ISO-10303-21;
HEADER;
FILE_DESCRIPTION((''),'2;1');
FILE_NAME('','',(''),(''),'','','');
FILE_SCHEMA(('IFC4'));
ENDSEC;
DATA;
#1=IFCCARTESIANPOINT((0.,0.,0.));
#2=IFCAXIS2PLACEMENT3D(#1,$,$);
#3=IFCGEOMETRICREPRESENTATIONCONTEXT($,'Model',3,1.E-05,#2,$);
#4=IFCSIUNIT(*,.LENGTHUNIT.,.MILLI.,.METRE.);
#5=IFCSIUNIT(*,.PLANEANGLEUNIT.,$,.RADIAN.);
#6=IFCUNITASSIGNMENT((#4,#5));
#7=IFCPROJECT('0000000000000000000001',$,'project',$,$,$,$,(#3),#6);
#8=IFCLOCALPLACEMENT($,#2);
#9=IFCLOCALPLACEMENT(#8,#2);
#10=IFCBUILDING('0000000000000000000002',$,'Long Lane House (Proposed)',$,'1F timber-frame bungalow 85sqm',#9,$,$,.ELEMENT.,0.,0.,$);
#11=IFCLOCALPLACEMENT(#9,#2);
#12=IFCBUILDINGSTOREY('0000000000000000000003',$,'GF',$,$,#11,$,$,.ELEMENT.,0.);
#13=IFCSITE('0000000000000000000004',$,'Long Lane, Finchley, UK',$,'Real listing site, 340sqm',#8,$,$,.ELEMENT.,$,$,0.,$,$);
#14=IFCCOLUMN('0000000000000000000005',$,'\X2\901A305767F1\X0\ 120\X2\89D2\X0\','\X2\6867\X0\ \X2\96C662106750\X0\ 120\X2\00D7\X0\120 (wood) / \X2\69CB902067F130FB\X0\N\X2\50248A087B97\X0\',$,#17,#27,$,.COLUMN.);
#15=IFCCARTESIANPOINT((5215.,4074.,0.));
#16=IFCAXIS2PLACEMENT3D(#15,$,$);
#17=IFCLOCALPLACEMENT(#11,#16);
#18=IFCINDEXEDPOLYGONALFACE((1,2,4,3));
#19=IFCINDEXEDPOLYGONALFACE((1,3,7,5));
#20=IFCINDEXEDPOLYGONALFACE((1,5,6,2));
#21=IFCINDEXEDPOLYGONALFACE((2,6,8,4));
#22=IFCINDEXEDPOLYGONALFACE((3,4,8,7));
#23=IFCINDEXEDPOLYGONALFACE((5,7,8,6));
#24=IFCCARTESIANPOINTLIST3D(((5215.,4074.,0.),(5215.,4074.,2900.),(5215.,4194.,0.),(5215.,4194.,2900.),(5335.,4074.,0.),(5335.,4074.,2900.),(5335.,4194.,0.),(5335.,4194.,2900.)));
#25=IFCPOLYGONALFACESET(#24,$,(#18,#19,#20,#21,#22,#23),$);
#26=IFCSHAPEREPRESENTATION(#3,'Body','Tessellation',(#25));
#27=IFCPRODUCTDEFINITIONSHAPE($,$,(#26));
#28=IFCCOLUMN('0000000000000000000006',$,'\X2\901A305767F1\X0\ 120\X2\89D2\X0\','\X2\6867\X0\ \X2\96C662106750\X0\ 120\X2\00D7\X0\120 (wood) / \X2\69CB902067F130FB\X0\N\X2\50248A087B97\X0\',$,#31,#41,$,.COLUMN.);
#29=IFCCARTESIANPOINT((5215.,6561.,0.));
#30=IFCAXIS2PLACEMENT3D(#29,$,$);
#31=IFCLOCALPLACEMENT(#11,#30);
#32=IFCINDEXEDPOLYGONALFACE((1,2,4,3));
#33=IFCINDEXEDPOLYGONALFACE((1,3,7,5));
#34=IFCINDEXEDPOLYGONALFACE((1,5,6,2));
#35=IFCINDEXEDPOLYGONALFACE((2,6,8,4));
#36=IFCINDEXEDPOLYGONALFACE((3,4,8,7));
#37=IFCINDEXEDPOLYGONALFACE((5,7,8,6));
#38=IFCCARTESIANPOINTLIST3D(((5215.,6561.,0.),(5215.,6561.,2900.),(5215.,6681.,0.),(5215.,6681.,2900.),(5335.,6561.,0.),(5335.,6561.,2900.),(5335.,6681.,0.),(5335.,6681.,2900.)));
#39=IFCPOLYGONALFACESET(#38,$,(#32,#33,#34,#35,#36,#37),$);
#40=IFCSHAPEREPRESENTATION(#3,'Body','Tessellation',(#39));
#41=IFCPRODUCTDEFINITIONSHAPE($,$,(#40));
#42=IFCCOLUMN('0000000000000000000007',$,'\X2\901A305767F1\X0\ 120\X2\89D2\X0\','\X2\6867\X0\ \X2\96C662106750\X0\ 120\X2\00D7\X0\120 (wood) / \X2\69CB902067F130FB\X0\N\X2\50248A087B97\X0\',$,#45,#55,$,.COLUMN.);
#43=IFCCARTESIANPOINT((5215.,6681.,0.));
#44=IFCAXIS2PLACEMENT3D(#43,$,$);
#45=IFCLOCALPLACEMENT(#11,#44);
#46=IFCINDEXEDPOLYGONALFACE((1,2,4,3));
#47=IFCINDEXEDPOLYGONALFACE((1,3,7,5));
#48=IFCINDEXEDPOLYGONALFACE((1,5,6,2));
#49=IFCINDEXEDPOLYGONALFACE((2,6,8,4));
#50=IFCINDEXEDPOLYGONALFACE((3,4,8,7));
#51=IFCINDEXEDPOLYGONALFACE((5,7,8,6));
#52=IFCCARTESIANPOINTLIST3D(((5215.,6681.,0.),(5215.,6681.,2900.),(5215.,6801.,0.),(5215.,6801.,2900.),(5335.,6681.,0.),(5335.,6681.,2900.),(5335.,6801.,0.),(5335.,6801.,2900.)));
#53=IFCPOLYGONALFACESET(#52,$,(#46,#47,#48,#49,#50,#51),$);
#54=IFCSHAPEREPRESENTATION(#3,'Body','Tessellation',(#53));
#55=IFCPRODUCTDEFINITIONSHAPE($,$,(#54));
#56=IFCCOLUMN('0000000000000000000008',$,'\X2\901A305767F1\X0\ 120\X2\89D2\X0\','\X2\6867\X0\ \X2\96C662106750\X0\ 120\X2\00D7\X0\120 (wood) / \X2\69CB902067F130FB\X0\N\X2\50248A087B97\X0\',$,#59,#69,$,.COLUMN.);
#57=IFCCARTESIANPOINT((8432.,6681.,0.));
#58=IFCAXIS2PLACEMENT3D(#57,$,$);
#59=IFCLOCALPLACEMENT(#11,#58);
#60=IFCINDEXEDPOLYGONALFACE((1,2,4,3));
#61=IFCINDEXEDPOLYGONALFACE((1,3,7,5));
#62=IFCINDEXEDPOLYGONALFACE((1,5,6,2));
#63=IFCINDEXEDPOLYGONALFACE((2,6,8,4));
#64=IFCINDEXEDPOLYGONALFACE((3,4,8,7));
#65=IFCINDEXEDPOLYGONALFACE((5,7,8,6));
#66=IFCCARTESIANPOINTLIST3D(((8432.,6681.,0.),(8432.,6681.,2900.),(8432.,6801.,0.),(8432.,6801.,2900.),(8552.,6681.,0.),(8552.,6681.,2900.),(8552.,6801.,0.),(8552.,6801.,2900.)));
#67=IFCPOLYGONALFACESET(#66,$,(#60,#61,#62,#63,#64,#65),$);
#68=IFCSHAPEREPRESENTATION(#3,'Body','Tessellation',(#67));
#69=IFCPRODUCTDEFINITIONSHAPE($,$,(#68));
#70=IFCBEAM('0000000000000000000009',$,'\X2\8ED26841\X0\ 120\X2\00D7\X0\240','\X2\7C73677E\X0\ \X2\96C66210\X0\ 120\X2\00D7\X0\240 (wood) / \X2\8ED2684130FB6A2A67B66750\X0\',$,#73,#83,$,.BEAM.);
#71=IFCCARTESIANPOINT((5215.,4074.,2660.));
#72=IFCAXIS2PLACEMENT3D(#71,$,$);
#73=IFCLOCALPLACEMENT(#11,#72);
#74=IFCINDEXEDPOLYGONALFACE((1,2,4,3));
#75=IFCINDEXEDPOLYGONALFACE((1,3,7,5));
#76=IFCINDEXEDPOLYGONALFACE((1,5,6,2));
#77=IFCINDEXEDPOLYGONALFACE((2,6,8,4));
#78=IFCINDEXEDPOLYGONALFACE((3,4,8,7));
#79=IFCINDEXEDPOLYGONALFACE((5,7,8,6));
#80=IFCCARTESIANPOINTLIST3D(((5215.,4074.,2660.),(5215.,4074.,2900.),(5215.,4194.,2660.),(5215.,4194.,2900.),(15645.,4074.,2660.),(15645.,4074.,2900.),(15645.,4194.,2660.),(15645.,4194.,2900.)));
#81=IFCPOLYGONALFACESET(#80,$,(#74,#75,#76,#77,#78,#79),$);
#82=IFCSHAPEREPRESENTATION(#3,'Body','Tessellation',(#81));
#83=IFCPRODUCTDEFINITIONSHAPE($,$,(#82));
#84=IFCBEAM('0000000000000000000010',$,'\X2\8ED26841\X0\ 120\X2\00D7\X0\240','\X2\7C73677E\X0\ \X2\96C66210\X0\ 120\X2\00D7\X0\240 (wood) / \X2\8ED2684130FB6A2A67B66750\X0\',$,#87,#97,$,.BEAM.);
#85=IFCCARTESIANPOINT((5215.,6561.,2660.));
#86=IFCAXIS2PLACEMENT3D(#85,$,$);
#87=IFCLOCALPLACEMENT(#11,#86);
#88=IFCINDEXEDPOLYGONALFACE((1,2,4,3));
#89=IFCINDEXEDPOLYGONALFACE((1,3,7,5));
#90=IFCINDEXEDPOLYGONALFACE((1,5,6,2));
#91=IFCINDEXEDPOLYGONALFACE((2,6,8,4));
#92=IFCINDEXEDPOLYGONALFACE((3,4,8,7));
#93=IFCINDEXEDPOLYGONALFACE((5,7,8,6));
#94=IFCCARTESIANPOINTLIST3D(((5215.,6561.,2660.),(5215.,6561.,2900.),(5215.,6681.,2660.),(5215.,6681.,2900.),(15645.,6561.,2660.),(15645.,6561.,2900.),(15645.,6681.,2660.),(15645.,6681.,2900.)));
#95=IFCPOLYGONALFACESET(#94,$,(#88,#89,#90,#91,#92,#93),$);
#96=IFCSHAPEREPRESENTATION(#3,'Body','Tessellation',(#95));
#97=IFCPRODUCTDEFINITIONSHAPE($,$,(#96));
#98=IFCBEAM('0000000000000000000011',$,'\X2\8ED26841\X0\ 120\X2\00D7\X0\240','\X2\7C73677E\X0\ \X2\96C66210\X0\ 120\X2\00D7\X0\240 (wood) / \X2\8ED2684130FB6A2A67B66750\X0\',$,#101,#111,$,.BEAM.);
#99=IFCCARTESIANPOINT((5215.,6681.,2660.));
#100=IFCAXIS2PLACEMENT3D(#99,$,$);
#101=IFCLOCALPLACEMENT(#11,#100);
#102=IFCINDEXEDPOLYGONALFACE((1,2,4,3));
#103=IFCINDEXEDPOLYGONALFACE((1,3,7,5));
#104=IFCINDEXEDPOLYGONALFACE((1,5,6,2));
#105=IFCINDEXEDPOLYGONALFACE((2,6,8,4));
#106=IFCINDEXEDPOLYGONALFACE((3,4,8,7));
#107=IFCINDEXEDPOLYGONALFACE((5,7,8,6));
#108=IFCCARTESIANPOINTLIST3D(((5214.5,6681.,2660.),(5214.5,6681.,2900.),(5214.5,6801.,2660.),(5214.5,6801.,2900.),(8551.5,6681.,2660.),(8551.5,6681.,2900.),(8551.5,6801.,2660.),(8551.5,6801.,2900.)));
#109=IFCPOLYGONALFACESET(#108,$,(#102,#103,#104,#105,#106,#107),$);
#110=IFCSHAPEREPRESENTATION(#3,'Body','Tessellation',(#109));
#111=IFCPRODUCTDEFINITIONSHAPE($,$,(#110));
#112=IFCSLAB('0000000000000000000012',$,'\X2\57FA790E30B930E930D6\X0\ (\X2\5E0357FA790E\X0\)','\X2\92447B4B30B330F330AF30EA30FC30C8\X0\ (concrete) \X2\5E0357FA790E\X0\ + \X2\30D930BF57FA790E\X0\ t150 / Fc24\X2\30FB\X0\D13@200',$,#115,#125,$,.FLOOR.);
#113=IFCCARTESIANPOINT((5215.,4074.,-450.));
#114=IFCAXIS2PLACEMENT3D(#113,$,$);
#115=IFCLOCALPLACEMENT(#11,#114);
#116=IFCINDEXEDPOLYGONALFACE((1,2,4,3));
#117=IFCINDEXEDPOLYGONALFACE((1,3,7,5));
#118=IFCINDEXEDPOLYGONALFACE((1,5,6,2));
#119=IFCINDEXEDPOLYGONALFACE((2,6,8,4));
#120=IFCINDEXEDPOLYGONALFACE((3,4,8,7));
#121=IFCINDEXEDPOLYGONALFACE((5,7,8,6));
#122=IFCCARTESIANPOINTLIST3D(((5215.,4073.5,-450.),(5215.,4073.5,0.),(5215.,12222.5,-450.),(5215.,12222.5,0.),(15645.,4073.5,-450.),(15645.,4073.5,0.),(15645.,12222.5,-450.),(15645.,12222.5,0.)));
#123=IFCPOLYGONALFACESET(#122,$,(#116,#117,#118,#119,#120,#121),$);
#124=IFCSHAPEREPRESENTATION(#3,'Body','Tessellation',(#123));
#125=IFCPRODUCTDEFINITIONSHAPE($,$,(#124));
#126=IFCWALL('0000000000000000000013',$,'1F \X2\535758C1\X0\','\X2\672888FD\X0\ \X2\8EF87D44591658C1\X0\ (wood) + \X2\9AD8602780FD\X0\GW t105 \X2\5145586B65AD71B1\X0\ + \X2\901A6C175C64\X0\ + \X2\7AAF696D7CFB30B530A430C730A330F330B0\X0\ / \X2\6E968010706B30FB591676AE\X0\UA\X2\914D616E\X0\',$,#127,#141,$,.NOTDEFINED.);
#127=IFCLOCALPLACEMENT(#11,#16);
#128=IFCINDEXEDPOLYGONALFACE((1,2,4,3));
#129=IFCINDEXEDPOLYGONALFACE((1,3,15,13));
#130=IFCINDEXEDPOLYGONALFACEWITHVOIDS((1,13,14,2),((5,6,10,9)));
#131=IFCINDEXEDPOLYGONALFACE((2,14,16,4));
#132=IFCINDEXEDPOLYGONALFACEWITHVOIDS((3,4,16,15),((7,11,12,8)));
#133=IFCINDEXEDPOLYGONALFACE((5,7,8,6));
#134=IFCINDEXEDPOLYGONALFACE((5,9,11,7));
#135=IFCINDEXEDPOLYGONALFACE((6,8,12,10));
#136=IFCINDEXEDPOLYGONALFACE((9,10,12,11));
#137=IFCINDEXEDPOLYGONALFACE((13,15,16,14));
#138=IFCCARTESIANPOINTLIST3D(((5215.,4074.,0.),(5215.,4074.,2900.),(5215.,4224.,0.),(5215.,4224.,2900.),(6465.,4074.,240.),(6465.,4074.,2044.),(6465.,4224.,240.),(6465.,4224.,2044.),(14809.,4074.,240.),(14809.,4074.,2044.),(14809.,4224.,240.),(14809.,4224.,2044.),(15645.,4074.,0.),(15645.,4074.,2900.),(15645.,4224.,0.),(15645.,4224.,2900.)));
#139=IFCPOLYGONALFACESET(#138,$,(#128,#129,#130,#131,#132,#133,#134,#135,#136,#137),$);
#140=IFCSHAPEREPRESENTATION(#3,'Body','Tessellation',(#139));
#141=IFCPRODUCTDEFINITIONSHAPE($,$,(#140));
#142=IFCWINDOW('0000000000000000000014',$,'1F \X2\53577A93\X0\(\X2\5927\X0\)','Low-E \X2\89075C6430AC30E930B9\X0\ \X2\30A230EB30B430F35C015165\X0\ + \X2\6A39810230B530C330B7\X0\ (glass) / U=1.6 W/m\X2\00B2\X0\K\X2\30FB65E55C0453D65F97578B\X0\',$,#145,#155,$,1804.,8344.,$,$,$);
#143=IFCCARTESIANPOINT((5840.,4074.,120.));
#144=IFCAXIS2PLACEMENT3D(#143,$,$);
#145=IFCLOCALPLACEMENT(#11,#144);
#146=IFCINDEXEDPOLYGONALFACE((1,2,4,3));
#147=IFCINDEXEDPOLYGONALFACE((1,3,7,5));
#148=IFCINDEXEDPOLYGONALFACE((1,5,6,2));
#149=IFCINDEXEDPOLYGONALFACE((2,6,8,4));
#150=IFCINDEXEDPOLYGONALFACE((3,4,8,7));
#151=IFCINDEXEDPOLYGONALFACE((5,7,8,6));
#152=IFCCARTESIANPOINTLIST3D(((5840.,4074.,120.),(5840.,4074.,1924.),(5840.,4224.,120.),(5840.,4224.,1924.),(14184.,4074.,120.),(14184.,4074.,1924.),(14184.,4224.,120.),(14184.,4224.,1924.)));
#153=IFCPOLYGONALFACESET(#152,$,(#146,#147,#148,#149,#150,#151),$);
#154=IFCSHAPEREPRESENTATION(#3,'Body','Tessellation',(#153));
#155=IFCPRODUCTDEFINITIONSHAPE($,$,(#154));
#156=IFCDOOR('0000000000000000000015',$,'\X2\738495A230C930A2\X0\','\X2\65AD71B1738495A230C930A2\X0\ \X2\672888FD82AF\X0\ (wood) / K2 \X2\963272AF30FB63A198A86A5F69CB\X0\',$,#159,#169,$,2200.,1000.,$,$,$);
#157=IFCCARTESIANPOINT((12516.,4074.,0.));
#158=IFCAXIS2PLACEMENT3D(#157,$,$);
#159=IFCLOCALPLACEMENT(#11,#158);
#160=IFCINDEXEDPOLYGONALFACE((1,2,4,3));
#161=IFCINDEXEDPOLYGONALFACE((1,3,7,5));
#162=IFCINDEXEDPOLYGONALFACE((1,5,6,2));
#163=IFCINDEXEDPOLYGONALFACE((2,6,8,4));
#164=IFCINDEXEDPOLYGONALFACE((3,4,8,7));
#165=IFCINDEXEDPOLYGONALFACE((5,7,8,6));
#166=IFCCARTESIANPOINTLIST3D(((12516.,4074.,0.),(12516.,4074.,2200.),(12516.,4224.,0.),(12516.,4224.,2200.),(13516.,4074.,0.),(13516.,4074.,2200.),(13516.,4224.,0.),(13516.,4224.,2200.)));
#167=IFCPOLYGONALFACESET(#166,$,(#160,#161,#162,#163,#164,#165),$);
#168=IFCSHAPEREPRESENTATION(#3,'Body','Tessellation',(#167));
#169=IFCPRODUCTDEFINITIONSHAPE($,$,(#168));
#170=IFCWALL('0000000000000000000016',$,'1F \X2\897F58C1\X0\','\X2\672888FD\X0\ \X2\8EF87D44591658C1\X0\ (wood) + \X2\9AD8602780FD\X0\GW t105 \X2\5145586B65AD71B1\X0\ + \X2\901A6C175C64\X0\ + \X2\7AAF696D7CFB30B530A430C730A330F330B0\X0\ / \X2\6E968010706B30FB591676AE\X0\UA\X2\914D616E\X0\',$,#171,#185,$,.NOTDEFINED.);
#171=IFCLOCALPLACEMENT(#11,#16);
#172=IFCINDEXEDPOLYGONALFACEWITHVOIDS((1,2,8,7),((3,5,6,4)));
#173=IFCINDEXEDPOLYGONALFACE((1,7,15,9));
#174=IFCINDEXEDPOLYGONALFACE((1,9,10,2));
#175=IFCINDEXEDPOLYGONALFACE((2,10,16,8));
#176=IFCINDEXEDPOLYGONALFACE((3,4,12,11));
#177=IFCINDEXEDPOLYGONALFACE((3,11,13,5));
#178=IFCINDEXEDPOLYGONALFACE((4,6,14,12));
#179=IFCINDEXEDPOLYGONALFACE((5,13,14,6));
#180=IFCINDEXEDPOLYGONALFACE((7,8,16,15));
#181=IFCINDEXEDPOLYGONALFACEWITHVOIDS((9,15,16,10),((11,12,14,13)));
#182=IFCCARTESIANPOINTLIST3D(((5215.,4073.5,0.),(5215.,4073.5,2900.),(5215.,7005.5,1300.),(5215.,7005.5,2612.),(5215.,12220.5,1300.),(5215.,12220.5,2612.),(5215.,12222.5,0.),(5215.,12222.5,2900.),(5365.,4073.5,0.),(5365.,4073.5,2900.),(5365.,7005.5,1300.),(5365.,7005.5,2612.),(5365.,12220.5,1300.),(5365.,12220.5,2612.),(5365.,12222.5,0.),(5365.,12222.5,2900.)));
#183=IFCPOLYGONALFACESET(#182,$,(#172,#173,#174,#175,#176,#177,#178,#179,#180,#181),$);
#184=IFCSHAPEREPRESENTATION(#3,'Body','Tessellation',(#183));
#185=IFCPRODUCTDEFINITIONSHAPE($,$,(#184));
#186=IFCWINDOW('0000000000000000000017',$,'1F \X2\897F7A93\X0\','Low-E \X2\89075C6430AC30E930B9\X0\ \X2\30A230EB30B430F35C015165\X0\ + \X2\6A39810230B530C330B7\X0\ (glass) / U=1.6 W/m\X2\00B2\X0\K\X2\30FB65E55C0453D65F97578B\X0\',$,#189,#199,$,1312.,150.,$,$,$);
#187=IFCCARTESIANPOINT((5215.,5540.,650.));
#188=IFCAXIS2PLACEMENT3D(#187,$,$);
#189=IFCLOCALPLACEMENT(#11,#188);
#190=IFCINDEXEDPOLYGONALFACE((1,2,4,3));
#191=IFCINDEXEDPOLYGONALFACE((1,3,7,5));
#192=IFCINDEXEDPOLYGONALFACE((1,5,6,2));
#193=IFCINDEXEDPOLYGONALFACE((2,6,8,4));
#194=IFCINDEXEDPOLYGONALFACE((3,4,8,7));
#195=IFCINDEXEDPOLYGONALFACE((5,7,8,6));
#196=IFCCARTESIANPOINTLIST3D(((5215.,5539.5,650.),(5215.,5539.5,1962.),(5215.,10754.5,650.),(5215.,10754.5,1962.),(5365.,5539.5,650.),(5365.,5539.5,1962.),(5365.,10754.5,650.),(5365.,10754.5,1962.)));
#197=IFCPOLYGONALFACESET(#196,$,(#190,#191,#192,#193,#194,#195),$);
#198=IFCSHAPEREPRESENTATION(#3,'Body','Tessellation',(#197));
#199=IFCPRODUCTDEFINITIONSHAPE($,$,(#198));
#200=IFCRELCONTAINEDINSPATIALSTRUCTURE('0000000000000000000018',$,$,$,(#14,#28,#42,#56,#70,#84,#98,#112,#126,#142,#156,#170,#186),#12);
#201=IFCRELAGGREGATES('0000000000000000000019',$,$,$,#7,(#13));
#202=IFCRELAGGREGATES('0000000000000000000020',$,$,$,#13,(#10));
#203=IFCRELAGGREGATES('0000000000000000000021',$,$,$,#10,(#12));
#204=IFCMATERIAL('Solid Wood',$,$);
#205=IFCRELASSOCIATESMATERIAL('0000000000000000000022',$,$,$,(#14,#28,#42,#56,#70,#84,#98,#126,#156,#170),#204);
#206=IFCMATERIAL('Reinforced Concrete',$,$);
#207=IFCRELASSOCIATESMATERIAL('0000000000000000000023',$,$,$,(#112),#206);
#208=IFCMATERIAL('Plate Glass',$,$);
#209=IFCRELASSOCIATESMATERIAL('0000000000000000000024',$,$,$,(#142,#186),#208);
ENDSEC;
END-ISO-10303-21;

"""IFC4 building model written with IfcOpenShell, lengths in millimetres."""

from ifc_helpers import new_model, si_unit, frame, frame_2d, origin, place, context, project, spatial, rectangle, extrude, material, element, fill, save


model = new_model("IFC4")

# Units and contexts
model_context = context("Model", 3, precision=1e-05, world=origin())
ifc_project = project(units=[si_unit("LENGTHUNIT", "METRE", prefix="MILLI"), si_unit("PLANEANGLEUNIT", "RADIAN")], contexts=[model_context])

# Site, building, storey
site_placement = place(None, origin())
site = spatial("IfcSite", under=ifc_project, at=site_placement, Name="Long Lane, Finchley, UK", ObjectType="Real listing site, 340sqm", CompositionType="ELEMENT", RefElevation=0.0)
building_placement = place(site_placement, origin())
building = spatial("IfcBuilding", under=site, at=building_placement, Name="Long Lane House (Proposed)", ObjectType="1F timber-frame bungalow 85sqm", CompositionType="ELEMENT", ElevationOfRefHeight=0.0, ElevationOfTerrain=0.0)
storey_placement = place(building_placement, origin())
storey = spatial("IfcBuildingStorey", under=building, at=storey_placement, Name="GF", CompositionType="ELEMENT", Elevation=0.0)

# Columns
ifc_material_1 = material(Name="Solid Wood")
column_1_placement = place(storey_placement, frame((5215.0, 4074.0, 0.0)))
element("IfcColumn", 1, at=column_1_placement, inside=storey, material=ifc_material_1, Name="通し柱 120角", Description="桧 集成材 120×120 (wood) / 構造柱・N値計算", PredefinedType="COLUMN", context=model_context, shape_type="SweptSolid", body=[
    extrude(rectangle(XDim=120.0, YDim=120.0, at=frame_2d((60.0, 60.0))), frame((5215.0, 4074.0, 0.0)), (0.0, 0.0, 1.0), 2900.0),
])
column_2_placement = place(storey_placement, frame((5215.0, 6561.0, 0.0)))
element("IfcColumn", 2, at=column_2_placement, inside=storey, material=ifc_material_1, Name="通し柱 120角", Description="桧 集成材 120×120 (wood) / 構造柱・N値計算", PredefinedType="COLUMN", context=model_context, shape_type="SweptSolid", body=[
    extrude(rectangle(XDim=120.0, YDim=120.0, at=frame_2d((60.0, 60.0))), frame((5215.0, 6561.0, 0.0)), (0.0, 0.0, 1.0), 2900.0),
])
column_3_placement = place(storey_placement, frame((5215.0, 6681.0, 0.0)))
element("IfcColumn", 3, at=column_3_placement, inside=storey, material=ifc_material_1, Name="通し柱 120角", Description="桧 集成材 120×120 (wood) / 構造柱・N値計算", PredefinedType="COLUMN", context=model_context, shape_type="SweptSolid", body=[
    extrude(rectangle(XDim=120.0, YDim=120.0, at=frame_2d((60.0, 60.0))), frame((5215.0, 6681.0, 0.0)), (0.0, 0.0, 1.0), 2900.0),
])
column_4_placement = place(storey_placement, frame((8432.0, 6681.0, 0.0)))
element("IfcColumn", 4, at=column_4_placement, inside=storey, material=ifc_material_1, Name="通し柱 120角", Description="桧 集成材 120×120 (wood) / 構造柱・N値計算", PredefinedType="COLUMN", context=model_context, shape_type="SweptSolid", body=[
    extrude(rectangle(XDim=120.0, YDim=120.0, at=frame_2d((60.0, 60.0))), frame((8432.0, 6681.0, 0.0)), (0.0, 0.0, 1.0), 2900.0),
])

# Beams
beam_1_placement = place(storey_placement, frame((5215.0, 4074.0, 2660.0)))
element("IfcBeam", 5, at=beam_1_placement, inside=storey, material=ifc_material_1, Name="軒桁 120×240", Description="米松 集成 120×240 (wood) / 軒桁・横架材", PredefinedType="BEAM", context=model_context, shape_type="SweptSolid", body=[
    extrude(rectangle(XDim=10430.0, YDim=120.0, at=frame_2d((5215.0, 60.0))), frame((5215.0, 4074.0, 2660.0)), (0.0, 0.0, 1.0), 240.0),
])
beam_2_placement = place(storey_placement, frame((5215.0, 6561.0, 2660.0)))
element("IfcBeam", 6, at=beam_2_placement, inside=storey, material=ifc_material_1, Name="軒桁 120×240", Description="米松 集成 120×240 (wood) / 軒桁・横架材", PredefinedType="BEAM", context=model_context, shape_type="SweptSolid", body=[
    extrude(rectangle(XDim=10430.0, YDim=120.0, at=frame_2d((5215.0, 60.0))), frame((5215.0, 6561.0, 2660.0)), (0.0, 0.0, 1.0), 240.0),
])
beam_3_placement = place(storey_placement, frame((5215.0, 6681.0, 2660.0)))
element("IfcBeam", 7, at=beam_3_placement, inside=storey, material=ifc_material_1, Name="軒桁 120×240", Description="米松 集成 120×240 (wood) / 軒桁・横架材", PredefinedType="BEAM", context=model_context, shape_type="SweptSolid", body=[
    extrude(rectangle(XDim=3337.0, YDim=120.0, at=frame_2d((1668.0, 60.0))), frame((5215.0, 6681.0, 2660.0)), (0.0, 0.0, 1.0), 240.0),
])

# Slab
ifc_material_2 = material(Name="Reinforced Concrete")
slab_1_placement = place(storey_placement, frame((5215.0, 4074.0, -450.0)))
element("IfcSlab", 8, at=slab_1_placement, inside=storey, material=ifc_material_2, Name="基礎スラブ (布基礎)", Description="鉄筋コンクリート (concrete) 布基礎 + ベタ基礎 t150 / Fc24・D13@200", PredefinedType="FLOOR", context=model_context, shape_type="SweptSolid", body=[
    extrude(rectangle(XDim=10430.0, YDim=8149.0, at=frame_2d((5215.0, 4074.0))), frame((5215.0, 4074.0, -450.0)), (0.0, 0.0, 1.0), 450.0),
])

# Wall, openings, window, door
wall_1_placement = place(storey_placement, frame((5215.0, 4074.0, 0.0)))
wall_1 = element("IfcWall", 9, at=wall_1_placement, inside=storey, material=ifc_material_1, Name="1F 南壁", Description="木製 軸組外壁 (wood) + 高性能GW t105 充填断熱 + 通気層 + 窯業系サイディング / 準耐火・外皮UA配慮", PredefinedType="NOTDEFINED", context=model_context, shape_type="SweptSolid", body=[
    extrude(rectangle(XDim=10430.0, YDim=150.0, at=frame_2d((5215.0, 75.0))), frame((5215.0, 4074.0, 0.0)), (0.0, 0.0, 1.0), 2900.0),
])
opening_1_placement = place(storey_placement, frame((5840.0, 4074.0, 120.0)))
opening_1 = element("IfcOpeningElement", 10, at=opening_1_placement, cuts=wall_1, PredefinedType="NOTDEFINED", context=model_context, shape_type="SweptSolid", body=[
    extrude(rectangle(XDim=8344.0, YDim=150.0, at=frame_2d((4172.0, 75.0))), frame((5840.0, 4074.0, 120.0)), (0.0, 0.0, 1.0), 1804.0),
])
opening_2_placement = place(storey_placement, frame((12516.0, 4074.0, 0.0)))
opening_2 = element("IfcOpeningElement", 11, at=opening_2_placement, cuts=wall_1, PredefinedType="NOTDEFINED", context=model_context, shape_type="SweptSolid", body=[
    extrude(rectangle(XDim=1000.0, YDim=150.0, at=frame_2d((500.0, 75.0))), frame((12516.0, 4074.0, 0.0)), (0.0, 0.0, 1.0), 2200.0),
])
ifc_material_3 = material(Name="Plate Glass")
window_1_placement = place(storey_placement, frame((5840.0, 4074.0, 120.0)))
window_1 = element("IfcWindow", 12, at=window_1_placement, inside=storey, material=ifc_material_3, Name="1F 南窓(大)", Description="Low-E 複層ガラス アルゴン封入 + 樹脂サッシ (glass) / U=1.6 W/m²K・日射取得型", OverallHeight=1804.0, OverallWidth=8344.0, context=model_context, shape_type="SweptSolid", body=[
    extrude(rectangle(XDim=8344.0, YDim=150.0, at=frame_2d((4172.0, 75.0))), frame((5840.0, 4074.0, 120.0)), (0.0, 0.0, 1.0), 1804.0),
])
fill(opening_1, window_1)
door_placement = place(storey_placement, frame((12516.0, 4074.0, 0.0)))
door = element("IfcDoor", 13, at=door_placement, inside=storey, material=ifc_material_1, Name="玄関ドア", Description="断熱玄関ドア 木製芯 (wood) / K2 防犯・採風機構", OverallHeight=2200.0, OverallWidth=1000.0, context=model_context, shape_type="SweptSolid", body=[
    extrude(rectangle(XDim=1000.0, YDim=150.0, at=frame_2d((500.0, 75.0))), frame((12516.0, 4074.0, 0.0)), (0.0, 0.0, 1.0), 2200.0),
])
fill(opening_2, door)

# Wall, opening, window
wall_2_placement = place(storey_placement, frame((5215.0, 4074.0, 0.0)))
wall_2 = element("IfcWall", 14, at=wall_2_placement, inside=storey, material=ifc_material_1, Name="1F 西壁", Description="木製 軸組外壁 (wood) + 高性能GW t105 充填断熱 + 通気層 + 窯業系サイディング / 準耐火・外皮UA配慮", PredefinedType="NOTDEFINED", context=model_context, shape_type="SweptSolid", body=[
    extrude(rectangle(XDim=150.0, YDim=8149.0, at=frame_2d((75.0, 4074.0))), frame((5215.0, 4074.0, 0.0)), (0.0, 0.0, 1.0), 2900.0),
])
opening_3_placement = place(storey_placement, frame((5215.0, 5540.0, 650.0)))
opening_3 = element("IfcOpeningElement", 15, at=opening_3_placement, cuts=wall_2, PredefinedType="NOTDEFINED", context=model_context, shape_type="SweptSolid", body=[
    extrude(rectangle(XDim=150.0, YDim=5215.0, at=frame_2d((75.0, 2607.0))), frame((5215.0, 5540.0, 650.0)), (0.0, 0.0, 1.0), 1312.0),
])
window_2_placement = place(storey_placement, frame((5215.0, 5540.0, 650.0)))
window_2 = element("IfcWindow", 16, at=window_2_placement, inside=storey, material=ifc_material_3, Name="1F 西窓", Description="Low-E 複層ガラス アルゴン封入 + 樹脂サッシ (glass) / U=1.6 W/m²K・日射取得型", OverallHeight=1312.0, OverallWidth=150.0, context=model_context, shape_type="SweptSolid", body=[
    extrude(rectangle(XDim=150.0, YDim=5215.0, at=frame_2d((75.0, 2607.0))), frame((5215.0, 5540.0, 650.0)), (0.0, 0.0, 1.0), 1312.0),
])
fill(opening_3, window_2)

save(model, "model.ifc")
